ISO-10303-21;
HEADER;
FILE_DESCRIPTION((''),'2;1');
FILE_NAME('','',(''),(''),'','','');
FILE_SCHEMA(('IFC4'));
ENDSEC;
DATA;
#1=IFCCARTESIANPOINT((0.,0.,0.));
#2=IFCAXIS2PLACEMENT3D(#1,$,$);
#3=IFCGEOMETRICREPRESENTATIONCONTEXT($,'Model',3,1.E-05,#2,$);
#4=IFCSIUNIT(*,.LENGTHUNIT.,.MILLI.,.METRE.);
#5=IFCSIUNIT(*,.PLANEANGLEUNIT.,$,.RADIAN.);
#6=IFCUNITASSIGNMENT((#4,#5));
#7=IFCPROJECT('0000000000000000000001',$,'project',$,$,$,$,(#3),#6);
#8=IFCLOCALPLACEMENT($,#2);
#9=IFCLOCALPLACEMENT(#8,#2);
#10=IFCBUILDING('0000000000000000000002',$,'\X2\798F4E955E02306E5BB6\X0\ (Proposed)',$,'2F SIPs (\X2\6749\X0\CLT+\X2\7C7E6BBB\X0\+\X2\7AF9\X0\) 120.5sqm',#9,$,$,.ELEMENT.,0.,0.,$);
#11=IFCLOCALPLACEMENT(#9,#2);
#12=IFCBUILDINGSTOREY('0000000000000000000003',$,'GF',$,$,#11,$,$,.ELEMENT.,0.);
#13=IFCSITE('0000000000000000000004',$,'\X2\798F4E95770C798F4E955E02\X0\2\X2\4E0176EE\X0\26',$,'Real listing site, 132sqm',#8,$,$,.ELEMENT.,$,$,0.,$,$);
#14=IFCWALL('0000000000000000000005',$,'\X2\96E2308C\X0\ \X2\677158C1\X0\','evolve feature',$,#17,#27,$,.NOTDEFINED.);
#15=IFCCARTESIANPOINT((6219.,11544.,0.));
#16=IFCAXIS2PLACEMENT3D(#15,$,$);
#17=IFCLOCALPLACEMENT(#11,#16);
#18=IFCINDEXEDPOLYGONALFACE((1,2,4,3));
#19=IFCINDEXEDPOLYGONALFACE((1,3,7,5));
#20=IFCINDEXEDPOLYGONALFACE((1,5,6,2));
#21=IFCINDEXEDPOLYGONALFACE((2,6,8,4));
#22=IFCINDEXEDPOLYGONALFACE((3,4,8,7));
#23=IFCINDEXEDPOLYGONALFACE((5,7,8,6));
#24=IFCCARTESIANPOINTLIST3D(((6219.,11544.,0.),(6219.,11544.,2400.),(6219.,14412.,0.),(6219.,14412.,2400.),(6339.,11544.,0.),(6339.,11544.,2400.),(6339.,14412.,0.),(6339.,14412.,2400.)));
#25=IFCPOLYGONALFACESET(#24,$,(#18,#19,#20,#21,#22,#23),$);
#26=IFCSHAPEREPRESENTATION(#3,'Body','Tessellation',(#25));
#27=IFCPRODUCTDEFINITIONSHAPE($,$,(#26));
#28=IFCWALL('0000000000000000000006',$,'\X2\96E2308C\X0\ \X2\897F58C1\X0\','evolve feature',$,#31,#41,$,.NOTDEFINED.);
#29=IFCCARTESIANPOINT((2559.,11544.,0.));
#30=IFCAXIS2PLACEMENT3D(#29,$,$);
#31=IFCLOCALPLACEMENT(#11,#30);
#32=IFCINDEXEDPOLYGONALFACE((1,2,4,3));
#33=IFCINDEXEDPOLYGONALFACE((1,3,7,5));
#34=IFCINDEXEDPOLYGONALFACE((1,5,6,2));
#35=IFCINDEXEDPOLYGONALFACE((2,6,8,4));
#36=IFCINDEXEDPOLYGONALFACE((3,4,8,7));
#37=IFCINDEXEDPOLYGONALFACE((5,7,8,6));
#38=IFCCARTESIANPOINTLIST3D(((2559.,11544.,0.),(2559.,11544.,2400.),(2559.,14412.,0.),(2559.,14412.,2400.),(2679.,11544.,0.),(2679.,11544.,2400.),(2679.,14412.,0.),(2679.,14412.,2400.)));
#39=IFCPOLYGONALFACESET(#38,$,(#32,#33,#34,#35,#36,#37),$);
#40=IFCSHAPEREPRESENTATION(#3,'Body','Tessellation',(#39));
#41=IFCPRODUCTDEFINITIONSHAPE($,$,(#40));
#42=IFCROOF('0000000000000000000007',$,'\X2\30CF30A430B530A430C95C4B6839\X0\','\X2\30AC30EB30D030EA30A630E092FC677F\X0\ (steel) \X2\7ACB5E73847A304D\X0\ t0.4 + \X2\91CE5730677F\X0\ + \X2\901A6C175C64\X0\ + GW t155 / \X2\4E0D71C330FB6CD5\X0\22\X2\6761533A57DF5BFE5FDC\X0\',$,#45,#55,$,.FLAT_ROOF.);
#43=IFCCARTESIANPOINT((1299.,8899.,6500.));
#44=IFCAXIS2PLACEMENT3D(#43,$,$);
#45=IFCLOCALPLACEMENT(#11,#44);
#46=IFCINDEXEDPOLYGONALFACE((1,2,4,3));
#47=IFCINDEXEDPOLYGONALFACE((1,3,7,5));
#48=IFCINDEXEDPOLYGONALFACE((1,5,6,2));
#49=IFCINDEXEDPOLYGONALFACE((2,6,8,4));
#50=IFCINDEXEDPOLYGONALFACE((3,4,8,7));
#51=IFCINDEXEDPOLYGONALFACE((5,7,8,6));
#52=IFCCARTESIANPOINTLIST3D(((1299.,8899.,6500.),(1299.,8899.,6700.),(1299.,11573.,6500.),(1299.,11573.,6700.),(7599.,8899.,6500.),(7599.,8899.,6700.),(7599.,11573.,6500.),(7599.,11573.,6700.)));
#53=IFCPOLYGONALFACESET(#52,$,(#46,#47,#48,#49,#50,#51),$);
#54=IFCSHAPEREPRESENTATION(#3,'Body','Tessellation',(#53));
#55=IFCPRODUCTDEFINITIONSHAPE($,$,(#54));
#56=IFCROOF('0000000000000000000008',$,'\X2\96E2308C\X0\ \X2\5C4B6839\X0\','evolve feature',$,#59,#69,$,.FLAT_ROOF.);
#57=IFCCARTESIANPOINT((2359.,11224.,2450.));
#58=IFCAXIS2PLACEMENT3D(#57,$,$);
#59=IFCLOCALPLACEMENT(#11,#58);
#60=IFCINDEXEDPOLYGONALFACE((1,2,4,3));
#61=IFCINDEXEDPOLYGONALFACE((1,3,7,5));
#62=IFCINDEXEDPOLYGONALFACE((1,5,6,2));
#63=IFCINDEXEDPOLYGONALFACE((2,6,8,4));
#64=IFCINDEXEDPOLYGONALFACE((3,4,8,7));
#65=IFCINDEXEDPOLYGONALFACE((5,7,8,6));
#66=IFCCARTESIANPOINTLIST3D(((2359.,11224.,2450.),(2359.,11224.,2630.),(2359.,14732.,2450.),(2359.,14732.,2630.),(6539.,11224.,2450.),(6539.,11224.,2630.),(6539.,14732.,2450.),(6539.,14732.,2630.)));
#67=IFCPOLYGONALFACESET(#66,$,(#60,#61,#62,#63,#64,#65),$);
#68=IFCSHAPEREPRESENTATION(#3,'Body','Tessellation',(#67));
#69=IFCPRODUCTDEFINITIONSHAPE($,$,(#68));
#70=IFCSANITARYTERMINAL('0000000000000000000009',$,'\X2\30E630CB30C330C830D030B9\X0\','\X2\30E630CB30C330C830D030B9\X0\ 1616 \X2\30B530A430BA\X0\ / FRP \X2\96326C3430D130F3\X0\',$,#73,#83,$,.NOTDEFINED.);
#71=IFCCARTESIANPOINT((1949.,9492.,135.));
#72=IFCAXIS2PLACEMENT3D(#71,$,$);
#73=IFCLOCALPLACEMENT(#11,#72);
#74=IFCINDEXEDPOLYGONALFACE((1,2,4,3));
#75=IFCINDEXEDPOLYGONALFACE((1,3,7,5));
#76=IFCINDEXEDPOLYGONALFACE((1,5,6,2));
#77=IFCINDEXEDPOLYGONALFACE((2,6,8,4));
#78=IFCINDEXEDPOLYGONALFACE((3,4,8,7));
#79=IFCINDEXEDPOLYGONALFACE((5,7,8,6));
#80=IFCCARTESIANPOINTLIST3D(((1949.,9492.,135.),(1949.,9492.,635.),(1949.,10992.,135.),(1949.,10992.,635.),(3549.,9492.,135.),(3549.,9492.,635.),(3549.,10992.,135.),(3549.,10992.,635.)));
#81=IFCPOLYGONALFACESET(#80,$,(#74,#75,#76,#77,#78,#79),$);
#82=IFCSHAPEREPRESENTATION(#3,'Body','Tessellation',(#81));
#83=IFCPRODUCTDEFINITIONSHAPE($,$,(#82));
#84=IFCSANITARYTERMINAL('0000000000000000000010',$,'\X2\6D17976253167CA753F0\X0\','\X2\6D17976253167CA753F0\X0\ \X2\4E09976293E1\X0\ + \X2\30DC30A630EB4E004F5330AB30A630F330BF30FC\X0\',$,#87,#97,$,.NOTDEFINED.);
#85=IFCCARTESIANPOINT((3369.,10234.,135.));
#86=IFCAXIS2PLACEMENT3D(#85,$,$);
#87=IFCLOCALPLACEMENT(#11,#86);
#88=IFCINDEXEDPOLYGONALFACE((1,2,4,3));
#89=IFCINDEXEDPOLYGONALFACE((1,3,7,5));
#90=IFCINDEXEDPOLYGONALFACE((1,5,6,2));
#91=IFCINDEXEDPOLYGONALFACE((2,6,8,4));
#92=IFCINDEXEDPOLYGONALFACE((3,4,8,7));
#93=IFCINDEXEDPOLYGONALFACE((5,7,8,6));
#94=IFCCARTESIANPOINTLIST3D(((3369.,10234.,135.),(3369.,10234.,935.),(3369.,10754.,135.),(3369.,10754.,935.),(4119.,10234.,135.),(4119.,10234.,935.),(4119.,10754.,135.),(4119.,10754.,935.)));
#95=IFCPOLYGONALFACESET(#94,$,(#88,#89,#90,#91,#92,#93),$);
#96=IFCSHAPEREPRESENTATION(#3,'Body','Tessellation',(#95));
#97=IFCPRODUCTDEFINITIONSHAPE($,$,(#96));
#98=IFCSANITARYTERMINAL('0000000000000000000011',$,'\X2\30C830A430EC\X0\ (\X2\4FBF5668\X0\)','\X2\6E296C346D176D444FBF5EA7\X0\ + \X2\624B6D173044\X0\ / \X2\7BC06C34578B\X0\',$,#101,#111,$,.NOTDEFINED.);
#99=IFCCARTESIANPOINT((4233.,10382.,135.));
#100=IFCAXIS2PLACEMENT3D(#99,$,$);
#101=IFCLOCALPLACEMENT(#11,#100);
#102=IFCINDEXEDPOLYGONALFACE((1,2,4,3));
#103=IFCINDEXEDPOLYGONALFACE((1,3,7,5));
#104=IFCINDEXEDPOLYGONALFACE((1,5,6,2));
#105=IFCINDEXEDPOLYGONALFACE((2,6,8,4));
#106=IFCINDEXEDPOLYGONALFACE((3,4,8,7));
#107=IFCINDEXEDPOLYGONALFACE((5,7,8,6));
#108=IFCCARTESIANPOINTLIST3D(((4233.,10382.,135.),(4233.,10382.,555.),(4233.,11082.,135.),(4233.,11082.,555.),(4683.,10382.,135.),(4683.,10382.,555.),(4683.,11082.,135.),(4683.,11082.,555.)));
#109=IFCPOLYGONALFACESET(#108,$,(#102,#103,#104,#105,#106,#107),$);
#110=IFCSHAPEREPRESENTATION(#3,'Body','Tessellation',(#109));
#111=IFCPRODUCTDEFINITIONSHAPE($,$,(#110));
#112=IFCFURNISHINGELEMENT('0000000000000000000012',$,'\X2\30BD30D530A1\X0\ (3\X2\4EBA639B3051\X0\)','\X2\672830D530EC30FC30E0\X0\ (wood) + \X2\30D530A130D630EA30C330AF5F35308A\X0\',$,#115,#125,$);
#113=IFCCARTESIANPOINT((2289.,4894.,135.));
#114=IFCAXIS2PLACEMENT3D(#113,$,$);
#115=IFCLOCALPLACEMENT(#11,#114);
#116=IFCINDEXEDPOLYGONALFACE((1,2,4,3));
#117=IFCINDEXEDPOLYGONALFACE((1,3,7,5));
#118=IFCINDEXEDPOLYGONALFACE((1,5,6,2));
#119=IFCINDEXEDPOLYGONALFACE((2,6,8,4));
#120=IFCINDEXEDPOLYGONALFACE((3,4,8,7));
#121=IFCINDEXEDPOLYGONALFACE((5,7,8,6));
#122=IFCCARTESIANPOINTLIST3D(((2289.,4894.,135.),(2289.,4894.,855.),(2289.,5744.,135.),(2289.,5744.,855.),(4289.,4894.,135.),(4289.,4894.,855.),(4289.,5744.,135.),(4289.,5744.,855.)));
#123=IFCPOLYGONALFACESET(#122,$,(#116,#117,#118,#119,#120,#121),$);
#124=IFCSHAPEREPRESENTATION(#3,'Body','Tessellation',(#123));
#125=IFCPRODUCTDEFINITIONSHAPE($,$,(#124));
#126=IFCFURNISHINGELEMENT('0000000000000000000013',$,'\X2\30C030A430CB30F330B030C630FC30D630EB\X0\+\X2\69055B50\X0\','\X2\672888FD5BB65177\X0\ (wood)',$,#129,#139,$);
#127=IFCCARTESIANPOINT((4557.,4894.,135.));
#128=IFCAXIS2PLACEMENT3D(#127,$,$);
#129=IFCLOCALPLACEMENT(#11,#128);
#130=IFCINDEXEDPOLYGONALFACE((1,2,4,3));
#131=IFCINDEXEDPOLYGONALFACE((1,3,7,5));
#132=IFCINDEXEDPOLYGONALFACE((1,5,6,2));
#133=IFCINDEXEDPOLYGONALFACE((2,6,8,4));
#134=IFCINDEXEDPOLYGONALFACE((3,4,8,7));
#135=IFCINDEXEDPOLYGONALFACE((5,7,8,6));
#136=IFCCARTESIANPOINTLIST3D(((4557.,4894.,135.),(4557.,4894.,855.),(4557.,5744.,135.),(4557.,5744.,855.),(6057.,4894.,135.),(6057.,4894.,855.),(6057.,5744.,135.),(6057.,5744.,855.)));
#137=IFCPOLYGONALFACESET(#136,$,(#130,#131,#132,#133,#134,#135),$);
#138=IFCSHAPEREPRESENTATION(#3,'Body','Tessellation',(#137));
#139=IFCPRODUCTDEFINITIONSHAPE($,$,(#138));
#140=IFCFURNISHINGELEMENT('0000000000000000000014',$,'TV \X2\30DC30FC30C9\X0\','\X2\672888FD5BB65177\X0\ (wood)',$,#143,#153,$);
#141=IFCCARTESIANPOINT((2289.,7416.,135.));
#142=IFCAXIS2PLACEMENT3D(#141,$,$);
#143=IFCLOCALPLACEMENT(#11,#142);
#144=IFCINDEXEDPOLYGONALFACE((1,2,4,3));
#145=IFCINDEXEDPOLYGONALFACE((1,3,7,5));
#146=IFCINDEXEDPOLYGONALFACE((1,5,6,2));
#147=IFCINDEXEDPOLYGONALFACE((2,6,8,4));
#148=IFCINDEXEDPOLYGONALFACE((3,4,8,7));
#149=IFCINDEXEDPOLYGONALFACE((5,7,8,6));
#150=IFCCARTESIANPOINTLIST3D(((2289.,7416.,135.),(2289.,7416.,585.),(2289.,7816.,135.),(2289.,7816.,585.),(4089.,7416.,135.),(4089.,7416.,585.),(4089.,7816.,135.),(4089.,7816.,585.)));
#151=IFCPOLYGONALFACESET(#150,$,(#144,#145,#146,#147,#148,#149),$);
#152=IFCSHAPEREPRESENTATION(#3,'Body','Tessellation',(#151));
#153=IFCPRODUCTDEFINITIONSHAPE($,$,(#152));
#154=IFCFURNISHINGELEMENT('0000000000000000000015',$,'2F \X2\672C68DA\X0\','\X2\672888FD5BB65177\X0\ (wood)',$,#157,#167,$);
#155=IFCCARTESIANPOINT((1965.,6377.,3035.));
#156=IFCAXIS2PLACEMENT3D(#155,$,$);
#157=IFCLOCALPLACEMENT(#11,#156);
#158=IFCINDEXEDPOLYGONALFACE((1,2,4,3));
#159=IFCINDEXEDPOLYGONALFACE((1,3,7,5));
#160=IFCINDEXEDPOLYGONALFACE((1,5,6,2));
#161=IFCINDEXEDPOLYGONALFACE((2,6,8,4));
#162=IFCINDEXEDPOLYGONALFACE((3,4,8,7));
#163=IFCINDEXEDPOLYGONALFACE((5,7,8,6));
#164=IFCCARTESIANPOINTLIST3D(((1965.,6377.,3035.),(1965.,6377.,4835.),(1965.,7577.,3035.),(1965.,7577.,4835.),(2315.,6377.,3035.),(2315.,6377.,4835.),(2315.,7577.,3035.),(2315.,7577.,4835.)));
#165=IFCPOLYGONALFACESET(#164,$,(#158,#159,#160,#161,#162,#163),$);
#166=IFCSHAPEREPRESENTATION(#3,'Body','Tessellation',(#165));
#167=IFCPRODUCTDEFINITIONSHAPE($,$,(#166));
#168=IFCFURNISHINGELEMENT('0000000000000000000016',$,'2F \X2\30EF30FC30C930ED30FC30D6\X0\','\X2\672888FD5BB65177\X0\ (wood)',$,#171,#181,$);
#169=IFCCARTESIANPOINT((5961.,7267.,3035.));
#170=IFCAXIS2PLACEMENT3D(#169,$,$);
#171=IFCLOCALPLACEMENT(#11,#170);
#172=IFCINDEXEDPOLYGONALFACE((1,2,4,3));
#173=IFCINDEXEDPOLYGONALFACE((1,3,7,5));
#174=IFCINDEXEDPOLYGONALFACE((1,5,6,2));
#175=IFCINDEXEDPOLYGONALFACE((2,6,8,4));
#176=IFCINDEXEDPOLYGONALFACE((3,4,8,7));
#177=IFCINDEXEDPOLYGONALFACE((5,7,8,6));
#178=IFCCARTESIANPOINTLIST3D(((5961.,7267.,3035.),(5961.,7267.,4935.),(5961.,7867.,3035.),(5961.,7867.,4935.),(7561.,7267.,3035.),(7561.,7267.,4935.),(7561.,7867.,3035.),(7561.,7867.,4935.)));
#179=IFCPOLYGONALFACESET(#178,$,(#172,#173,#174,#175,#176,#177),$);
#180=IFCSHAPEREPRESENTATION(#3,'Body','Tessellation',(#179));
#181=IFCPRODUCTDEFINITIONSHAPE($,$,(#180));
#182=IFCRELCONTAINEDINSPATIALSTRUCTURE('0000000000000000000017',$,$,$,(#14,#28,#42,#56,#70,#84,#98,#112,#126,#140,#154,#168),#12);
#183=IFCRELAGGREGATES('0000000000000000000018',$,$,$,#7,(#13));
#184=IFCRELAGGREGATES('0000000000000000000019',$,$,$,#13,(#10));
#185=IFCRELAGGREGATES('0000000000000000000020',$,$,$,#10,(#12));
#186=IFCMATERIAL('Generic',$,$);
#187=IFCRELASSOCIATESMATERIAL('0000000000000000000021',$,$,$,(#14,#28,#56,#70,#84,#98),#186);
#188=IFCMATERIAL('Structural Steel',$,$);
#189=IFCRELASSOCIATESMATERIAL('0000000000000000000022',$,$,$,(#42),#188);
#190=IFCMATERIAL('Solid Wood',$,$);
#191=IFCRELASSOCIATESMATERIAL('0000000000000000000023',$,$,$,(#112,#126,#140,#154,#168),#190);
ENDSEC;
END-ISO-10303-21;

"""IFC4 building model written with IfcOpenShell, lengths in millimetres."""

from ifc_helpers import new_model, si_unit, frame, frame_2d, origin, place, context, project, spatial, rectangle, extrude, material, element, save


model = new_model("IFC4")

# Units and contexts
model_context = context("Model", 3, precision=1e-05, world=origin())
ifc_project = project(units=[si_unit("LENGTHUNIT", "METRE", prefix="MILLI"), si_unit("PLANEANGLEUNIT", "RADIAN")], contexts=[model_context])

# Site, building, storey
site_placement = place(None, origin())
site = spatial("IfcSite", under=ifc_project, at=site_placement, Name="福井県福井市2丁目26", ObjectType="Real listing site, 132sqm", CompositionType="ELEMENT", RefElevation=0.0)
building_placement = place(site_placement, origin())
building = spatial("IfcBuilding", under=site, at=building_placement, Name="福井市の家 (Proposed)", ObjectType="2F SIPs (杉CLT+籾殻+竹) 120.5sqm", CompositionType="ELEMENT", ElevationOfRefHeight=0.0, ElevationOfTerrain=0.0)
storey_placement = place(building_placement, origin())
storey = spatial("IfcBuildingStorey", under=building, at=storey_placement, Name="GF", CompositionType="ELEMENT", Elevation=0.0)

# Shared definitions
ifc_material_1 = material(Name="Generic")

# Shared definitions
ifc_material_2 = material(Name="Solid Wood")

# Walls
wall_1_placement = place(storey_placement, frame((6219.0, 11544.0, 0.0)))
element("IfcWall", 1, at=wall_1_placement, inside=storey, material=ifc_material_1, Name="離れ 東壁", Description="evolve feature", PredefinedType="NOTDEFINED", context=model_context, shape_type="SweptSolid", body=[
    extrude(rectangle(XDim=120.0, YDim=2868.0, at=frame_2d((60.0, 1434.0))), frame((6219.0, 11544.0, 0.0)), (0.0, 0.0, 1.0), 2400.0),
])
wall_2_placement = place(storey_placement, frame((2559.0, 11544.0, 0.0)))
element("IfcWall", 2, at=wall_2_placement, inside=storey, material=ifc_material_1, Name="離れ 西壁", Description="evolve feature", PredefinedType="NOTDEFINED", context=model_context, shape_type="SweptSolid", body=[
    extrude(rectangle(XDim=120.0, YDim=2868.0, at=frame_2d((60.0, 1434.0))), frame((2559.0, 11544.0, 0.0)), (0.0, 0.0, 1.0), 2400.0),
])

# Roofs
ifc_material_3 = material(Name="Structural Steel")
roof_1_placement = place(storey_placement, frame((1299.0, 8899.0, 6500.0)))
element("IfcRoof", 3, at=roof_1_placement, inside=storey, material=ifc_material_3, Name="ハイサイド屋根", Description="ガルバリウム鋼板 (steel) 立平葺き t0.4 + 野地板 + 通気層 + GW t155 / 不燃・法22条区域対応", PredefinedType="FLAT_ROOF", context=model_context, shape_type="SweptSolid", body=[
    extrude(rectangle(XDim=6300.0, YDim=2674.0, at=frame_2d((3150.0, 1337.0))), frame((1299.0, 8899.0, 6500.0)), (0.0, 0.0, 1.0), 200.0),
])
roof_2_placement = place(storey_placement, frame((2359.0, 11224.0, 2450.0)))
element("IfcRoof", 4, at=roof_2_placement, inside=storey, material=ifc_material_1, Name="離れ 屋根", Description="evolve feature", PredefinedType="FLAT_ROOF", context=model_context, shape_type="SweptSolid", body=[
    extrude(rectangle(XDim=4180.0, YDim=3508.0, at=frame_2d((2090.0, 1754.0))), frame((2359.0, 11224.0, 2450.0)), (0.0, 0.0, 1.0), 180.0),
])

# Sanitary terminals
sanitary_terminal_1_placement = place(storey_placement, frame((1949.0, 9492.0, 135.0)))
element("IfcSanitaryTerminal", 5, at=sanitary_terminal_1_placement, inside=storey, material=ifc_material_1, Name="ユニットバス", Description="ユニットバス 1616 サイズ / FRP 防水パン", PredefinedType="NOTDEFINED", context=model_context, shape_type="SweptSolid", body=[
    extrude(rectangle(XDim=1600.0, YDim=1500.0, at=frame_2d((800.0, 750.0))), frame((1949.0, 9492.0, 135.0)), (0.0, 0.0, 1.0), 500.0),
])
sanitary_terminal_2_placement = place(storey_placement, frame((3369.0, 10234.0, 135.0)))
element("IfcSanitaryTerminal", 6, at=sanitary_terminal_2_placement, inside=storey, material=ifc_material_1, Name="洗面化粧台", Description="洗面化粧台 三面鏡 + ボウル一体カウンター", PredefinedType="NOTDEFINED", context=model_context, shape_type="SweptSolid", body=[
    extrude(rectangle(XDim=750.0, YDim=520.0, at=frame_2d((375.0, 260.0))), frame((3369.0, 10234.0, 135.0)), (0.0, 0.0, 1.0), 800.0),
])
sanitary_terminal_3_placement = place(storey_placement, frame((4233.0, 10382.0, 135.0)))
element("IfcSanitaryTerminal", 7, at=sanitary_terminal_3_placement, inside=storey, material=ifc_material_1, Name="トイレ (便器)", Description="温水洗浄便座 + 手洗い / 節水型", PredefinedType="NOTDEFINED", context=model_context, shape_type="SweptSolid", body=[
    extrude(rectangle(XDim=450.0, YDim=700.0, at=frame_2d((225.0, 350.0))), frame((4233.0, 10382.0, 135.0)), (0.0, 0.0, 1.0), 420.0),
])

# Furnishing elements
furnishing_1_placement = place(storey_placement, frame((2289.0, 4894.0, 135.0)))
element("IfcFurnishingElement", 8, at=furnishing_1_placement, inside=storey, material=ifc_material_2, Name="ソファ (3人掛け)", Description="木フレーム (wood) + ファブリック張り", context=model_context, shape_type="SweptSolid", body=[
    extrude(rectangle(XDim=2000.0, YDim=850.0, at=frame_2d((1000.0, 425.0))), frame((2289.0, 4894.0, 135.0)), (0.0, 0.0, 1.0), 720.0),
])
furnishing_2_placement = place(storey_placement, frame((4557.0, 4894.0, 135.0)))
element("IfcFurnishingElement", 9, at=furnishing_2_placement, inside=storey, material=ifc_material_2, Name="ダイニングテーブル+椅子", Description="木製家具 (wood)", context=model_context, shape_type="SweptSolid", body=[
    extrude(rectangle(XDim=1500.0, YDim=850.0, at=frame_2d((750.0, 425.0))), frame((4557.0, 4894.0, 135.0)), (0.0, 0.0, 1.0), 720.0),
])
furnishing_3_placement = place(storey_placement, frame((2289.0, 7416.0, 135.0)))
element("IfcFurnishingElement", 10, at=furnishing_3_placement, inside=storey, material=ifc_material_2, Name="TV ボード", Description="木製家具 (wood)", context=model_context, shape_type="SweptSolid", body=[
    extrude(rectangle(XDim=1800.0, YDim=400.0, at=frame_2d((900.0, 200.0))), frame((2289.0, 7416.0, 135.0)), (0.0, 0.0, 1.0), 450.0),
])
furnishing_4_placement = place(storey_placement, frame((1965.0, 6377.0, 3035.0)))
element("IfcFurnishingElement", 11, at=furnishing_4_placement, inside=storey, material=ifc_material_2, Name="2F 本棚", Description="木製家具 (wood)", context=model_context, shape_type="SweptSolid", body=[
    extrude(rectangle(XDim=350.0, YDim=1200.0, at=frame_2d((175.0, 600.0))), frame((1965.0, 6377.0, 3035.0)), (0.0, 0.0, 1.0), 1800.0),
])
furnishing_5_placement = place(storey_placement, frame((5961.0, 7267.0, 3035.0)))
element("IfcFurnishingElement", 12, at=furnishing_5_placement, inside=storey, material=ifc_material_2, Name="2F ワードローブ", Description="木製家具 (wood)", context=model_context, shape_type="SweptSolid", body=[
    extrude(rectangle(XDim=1600.0, YDim=600.0, at=frame_2d((800.0, 300.0))), frame((5961.0, 7267.0, 3035.0)), (0.0, 0.0, 1.0), 1900.0),
])

save(model, "model.ifc")
